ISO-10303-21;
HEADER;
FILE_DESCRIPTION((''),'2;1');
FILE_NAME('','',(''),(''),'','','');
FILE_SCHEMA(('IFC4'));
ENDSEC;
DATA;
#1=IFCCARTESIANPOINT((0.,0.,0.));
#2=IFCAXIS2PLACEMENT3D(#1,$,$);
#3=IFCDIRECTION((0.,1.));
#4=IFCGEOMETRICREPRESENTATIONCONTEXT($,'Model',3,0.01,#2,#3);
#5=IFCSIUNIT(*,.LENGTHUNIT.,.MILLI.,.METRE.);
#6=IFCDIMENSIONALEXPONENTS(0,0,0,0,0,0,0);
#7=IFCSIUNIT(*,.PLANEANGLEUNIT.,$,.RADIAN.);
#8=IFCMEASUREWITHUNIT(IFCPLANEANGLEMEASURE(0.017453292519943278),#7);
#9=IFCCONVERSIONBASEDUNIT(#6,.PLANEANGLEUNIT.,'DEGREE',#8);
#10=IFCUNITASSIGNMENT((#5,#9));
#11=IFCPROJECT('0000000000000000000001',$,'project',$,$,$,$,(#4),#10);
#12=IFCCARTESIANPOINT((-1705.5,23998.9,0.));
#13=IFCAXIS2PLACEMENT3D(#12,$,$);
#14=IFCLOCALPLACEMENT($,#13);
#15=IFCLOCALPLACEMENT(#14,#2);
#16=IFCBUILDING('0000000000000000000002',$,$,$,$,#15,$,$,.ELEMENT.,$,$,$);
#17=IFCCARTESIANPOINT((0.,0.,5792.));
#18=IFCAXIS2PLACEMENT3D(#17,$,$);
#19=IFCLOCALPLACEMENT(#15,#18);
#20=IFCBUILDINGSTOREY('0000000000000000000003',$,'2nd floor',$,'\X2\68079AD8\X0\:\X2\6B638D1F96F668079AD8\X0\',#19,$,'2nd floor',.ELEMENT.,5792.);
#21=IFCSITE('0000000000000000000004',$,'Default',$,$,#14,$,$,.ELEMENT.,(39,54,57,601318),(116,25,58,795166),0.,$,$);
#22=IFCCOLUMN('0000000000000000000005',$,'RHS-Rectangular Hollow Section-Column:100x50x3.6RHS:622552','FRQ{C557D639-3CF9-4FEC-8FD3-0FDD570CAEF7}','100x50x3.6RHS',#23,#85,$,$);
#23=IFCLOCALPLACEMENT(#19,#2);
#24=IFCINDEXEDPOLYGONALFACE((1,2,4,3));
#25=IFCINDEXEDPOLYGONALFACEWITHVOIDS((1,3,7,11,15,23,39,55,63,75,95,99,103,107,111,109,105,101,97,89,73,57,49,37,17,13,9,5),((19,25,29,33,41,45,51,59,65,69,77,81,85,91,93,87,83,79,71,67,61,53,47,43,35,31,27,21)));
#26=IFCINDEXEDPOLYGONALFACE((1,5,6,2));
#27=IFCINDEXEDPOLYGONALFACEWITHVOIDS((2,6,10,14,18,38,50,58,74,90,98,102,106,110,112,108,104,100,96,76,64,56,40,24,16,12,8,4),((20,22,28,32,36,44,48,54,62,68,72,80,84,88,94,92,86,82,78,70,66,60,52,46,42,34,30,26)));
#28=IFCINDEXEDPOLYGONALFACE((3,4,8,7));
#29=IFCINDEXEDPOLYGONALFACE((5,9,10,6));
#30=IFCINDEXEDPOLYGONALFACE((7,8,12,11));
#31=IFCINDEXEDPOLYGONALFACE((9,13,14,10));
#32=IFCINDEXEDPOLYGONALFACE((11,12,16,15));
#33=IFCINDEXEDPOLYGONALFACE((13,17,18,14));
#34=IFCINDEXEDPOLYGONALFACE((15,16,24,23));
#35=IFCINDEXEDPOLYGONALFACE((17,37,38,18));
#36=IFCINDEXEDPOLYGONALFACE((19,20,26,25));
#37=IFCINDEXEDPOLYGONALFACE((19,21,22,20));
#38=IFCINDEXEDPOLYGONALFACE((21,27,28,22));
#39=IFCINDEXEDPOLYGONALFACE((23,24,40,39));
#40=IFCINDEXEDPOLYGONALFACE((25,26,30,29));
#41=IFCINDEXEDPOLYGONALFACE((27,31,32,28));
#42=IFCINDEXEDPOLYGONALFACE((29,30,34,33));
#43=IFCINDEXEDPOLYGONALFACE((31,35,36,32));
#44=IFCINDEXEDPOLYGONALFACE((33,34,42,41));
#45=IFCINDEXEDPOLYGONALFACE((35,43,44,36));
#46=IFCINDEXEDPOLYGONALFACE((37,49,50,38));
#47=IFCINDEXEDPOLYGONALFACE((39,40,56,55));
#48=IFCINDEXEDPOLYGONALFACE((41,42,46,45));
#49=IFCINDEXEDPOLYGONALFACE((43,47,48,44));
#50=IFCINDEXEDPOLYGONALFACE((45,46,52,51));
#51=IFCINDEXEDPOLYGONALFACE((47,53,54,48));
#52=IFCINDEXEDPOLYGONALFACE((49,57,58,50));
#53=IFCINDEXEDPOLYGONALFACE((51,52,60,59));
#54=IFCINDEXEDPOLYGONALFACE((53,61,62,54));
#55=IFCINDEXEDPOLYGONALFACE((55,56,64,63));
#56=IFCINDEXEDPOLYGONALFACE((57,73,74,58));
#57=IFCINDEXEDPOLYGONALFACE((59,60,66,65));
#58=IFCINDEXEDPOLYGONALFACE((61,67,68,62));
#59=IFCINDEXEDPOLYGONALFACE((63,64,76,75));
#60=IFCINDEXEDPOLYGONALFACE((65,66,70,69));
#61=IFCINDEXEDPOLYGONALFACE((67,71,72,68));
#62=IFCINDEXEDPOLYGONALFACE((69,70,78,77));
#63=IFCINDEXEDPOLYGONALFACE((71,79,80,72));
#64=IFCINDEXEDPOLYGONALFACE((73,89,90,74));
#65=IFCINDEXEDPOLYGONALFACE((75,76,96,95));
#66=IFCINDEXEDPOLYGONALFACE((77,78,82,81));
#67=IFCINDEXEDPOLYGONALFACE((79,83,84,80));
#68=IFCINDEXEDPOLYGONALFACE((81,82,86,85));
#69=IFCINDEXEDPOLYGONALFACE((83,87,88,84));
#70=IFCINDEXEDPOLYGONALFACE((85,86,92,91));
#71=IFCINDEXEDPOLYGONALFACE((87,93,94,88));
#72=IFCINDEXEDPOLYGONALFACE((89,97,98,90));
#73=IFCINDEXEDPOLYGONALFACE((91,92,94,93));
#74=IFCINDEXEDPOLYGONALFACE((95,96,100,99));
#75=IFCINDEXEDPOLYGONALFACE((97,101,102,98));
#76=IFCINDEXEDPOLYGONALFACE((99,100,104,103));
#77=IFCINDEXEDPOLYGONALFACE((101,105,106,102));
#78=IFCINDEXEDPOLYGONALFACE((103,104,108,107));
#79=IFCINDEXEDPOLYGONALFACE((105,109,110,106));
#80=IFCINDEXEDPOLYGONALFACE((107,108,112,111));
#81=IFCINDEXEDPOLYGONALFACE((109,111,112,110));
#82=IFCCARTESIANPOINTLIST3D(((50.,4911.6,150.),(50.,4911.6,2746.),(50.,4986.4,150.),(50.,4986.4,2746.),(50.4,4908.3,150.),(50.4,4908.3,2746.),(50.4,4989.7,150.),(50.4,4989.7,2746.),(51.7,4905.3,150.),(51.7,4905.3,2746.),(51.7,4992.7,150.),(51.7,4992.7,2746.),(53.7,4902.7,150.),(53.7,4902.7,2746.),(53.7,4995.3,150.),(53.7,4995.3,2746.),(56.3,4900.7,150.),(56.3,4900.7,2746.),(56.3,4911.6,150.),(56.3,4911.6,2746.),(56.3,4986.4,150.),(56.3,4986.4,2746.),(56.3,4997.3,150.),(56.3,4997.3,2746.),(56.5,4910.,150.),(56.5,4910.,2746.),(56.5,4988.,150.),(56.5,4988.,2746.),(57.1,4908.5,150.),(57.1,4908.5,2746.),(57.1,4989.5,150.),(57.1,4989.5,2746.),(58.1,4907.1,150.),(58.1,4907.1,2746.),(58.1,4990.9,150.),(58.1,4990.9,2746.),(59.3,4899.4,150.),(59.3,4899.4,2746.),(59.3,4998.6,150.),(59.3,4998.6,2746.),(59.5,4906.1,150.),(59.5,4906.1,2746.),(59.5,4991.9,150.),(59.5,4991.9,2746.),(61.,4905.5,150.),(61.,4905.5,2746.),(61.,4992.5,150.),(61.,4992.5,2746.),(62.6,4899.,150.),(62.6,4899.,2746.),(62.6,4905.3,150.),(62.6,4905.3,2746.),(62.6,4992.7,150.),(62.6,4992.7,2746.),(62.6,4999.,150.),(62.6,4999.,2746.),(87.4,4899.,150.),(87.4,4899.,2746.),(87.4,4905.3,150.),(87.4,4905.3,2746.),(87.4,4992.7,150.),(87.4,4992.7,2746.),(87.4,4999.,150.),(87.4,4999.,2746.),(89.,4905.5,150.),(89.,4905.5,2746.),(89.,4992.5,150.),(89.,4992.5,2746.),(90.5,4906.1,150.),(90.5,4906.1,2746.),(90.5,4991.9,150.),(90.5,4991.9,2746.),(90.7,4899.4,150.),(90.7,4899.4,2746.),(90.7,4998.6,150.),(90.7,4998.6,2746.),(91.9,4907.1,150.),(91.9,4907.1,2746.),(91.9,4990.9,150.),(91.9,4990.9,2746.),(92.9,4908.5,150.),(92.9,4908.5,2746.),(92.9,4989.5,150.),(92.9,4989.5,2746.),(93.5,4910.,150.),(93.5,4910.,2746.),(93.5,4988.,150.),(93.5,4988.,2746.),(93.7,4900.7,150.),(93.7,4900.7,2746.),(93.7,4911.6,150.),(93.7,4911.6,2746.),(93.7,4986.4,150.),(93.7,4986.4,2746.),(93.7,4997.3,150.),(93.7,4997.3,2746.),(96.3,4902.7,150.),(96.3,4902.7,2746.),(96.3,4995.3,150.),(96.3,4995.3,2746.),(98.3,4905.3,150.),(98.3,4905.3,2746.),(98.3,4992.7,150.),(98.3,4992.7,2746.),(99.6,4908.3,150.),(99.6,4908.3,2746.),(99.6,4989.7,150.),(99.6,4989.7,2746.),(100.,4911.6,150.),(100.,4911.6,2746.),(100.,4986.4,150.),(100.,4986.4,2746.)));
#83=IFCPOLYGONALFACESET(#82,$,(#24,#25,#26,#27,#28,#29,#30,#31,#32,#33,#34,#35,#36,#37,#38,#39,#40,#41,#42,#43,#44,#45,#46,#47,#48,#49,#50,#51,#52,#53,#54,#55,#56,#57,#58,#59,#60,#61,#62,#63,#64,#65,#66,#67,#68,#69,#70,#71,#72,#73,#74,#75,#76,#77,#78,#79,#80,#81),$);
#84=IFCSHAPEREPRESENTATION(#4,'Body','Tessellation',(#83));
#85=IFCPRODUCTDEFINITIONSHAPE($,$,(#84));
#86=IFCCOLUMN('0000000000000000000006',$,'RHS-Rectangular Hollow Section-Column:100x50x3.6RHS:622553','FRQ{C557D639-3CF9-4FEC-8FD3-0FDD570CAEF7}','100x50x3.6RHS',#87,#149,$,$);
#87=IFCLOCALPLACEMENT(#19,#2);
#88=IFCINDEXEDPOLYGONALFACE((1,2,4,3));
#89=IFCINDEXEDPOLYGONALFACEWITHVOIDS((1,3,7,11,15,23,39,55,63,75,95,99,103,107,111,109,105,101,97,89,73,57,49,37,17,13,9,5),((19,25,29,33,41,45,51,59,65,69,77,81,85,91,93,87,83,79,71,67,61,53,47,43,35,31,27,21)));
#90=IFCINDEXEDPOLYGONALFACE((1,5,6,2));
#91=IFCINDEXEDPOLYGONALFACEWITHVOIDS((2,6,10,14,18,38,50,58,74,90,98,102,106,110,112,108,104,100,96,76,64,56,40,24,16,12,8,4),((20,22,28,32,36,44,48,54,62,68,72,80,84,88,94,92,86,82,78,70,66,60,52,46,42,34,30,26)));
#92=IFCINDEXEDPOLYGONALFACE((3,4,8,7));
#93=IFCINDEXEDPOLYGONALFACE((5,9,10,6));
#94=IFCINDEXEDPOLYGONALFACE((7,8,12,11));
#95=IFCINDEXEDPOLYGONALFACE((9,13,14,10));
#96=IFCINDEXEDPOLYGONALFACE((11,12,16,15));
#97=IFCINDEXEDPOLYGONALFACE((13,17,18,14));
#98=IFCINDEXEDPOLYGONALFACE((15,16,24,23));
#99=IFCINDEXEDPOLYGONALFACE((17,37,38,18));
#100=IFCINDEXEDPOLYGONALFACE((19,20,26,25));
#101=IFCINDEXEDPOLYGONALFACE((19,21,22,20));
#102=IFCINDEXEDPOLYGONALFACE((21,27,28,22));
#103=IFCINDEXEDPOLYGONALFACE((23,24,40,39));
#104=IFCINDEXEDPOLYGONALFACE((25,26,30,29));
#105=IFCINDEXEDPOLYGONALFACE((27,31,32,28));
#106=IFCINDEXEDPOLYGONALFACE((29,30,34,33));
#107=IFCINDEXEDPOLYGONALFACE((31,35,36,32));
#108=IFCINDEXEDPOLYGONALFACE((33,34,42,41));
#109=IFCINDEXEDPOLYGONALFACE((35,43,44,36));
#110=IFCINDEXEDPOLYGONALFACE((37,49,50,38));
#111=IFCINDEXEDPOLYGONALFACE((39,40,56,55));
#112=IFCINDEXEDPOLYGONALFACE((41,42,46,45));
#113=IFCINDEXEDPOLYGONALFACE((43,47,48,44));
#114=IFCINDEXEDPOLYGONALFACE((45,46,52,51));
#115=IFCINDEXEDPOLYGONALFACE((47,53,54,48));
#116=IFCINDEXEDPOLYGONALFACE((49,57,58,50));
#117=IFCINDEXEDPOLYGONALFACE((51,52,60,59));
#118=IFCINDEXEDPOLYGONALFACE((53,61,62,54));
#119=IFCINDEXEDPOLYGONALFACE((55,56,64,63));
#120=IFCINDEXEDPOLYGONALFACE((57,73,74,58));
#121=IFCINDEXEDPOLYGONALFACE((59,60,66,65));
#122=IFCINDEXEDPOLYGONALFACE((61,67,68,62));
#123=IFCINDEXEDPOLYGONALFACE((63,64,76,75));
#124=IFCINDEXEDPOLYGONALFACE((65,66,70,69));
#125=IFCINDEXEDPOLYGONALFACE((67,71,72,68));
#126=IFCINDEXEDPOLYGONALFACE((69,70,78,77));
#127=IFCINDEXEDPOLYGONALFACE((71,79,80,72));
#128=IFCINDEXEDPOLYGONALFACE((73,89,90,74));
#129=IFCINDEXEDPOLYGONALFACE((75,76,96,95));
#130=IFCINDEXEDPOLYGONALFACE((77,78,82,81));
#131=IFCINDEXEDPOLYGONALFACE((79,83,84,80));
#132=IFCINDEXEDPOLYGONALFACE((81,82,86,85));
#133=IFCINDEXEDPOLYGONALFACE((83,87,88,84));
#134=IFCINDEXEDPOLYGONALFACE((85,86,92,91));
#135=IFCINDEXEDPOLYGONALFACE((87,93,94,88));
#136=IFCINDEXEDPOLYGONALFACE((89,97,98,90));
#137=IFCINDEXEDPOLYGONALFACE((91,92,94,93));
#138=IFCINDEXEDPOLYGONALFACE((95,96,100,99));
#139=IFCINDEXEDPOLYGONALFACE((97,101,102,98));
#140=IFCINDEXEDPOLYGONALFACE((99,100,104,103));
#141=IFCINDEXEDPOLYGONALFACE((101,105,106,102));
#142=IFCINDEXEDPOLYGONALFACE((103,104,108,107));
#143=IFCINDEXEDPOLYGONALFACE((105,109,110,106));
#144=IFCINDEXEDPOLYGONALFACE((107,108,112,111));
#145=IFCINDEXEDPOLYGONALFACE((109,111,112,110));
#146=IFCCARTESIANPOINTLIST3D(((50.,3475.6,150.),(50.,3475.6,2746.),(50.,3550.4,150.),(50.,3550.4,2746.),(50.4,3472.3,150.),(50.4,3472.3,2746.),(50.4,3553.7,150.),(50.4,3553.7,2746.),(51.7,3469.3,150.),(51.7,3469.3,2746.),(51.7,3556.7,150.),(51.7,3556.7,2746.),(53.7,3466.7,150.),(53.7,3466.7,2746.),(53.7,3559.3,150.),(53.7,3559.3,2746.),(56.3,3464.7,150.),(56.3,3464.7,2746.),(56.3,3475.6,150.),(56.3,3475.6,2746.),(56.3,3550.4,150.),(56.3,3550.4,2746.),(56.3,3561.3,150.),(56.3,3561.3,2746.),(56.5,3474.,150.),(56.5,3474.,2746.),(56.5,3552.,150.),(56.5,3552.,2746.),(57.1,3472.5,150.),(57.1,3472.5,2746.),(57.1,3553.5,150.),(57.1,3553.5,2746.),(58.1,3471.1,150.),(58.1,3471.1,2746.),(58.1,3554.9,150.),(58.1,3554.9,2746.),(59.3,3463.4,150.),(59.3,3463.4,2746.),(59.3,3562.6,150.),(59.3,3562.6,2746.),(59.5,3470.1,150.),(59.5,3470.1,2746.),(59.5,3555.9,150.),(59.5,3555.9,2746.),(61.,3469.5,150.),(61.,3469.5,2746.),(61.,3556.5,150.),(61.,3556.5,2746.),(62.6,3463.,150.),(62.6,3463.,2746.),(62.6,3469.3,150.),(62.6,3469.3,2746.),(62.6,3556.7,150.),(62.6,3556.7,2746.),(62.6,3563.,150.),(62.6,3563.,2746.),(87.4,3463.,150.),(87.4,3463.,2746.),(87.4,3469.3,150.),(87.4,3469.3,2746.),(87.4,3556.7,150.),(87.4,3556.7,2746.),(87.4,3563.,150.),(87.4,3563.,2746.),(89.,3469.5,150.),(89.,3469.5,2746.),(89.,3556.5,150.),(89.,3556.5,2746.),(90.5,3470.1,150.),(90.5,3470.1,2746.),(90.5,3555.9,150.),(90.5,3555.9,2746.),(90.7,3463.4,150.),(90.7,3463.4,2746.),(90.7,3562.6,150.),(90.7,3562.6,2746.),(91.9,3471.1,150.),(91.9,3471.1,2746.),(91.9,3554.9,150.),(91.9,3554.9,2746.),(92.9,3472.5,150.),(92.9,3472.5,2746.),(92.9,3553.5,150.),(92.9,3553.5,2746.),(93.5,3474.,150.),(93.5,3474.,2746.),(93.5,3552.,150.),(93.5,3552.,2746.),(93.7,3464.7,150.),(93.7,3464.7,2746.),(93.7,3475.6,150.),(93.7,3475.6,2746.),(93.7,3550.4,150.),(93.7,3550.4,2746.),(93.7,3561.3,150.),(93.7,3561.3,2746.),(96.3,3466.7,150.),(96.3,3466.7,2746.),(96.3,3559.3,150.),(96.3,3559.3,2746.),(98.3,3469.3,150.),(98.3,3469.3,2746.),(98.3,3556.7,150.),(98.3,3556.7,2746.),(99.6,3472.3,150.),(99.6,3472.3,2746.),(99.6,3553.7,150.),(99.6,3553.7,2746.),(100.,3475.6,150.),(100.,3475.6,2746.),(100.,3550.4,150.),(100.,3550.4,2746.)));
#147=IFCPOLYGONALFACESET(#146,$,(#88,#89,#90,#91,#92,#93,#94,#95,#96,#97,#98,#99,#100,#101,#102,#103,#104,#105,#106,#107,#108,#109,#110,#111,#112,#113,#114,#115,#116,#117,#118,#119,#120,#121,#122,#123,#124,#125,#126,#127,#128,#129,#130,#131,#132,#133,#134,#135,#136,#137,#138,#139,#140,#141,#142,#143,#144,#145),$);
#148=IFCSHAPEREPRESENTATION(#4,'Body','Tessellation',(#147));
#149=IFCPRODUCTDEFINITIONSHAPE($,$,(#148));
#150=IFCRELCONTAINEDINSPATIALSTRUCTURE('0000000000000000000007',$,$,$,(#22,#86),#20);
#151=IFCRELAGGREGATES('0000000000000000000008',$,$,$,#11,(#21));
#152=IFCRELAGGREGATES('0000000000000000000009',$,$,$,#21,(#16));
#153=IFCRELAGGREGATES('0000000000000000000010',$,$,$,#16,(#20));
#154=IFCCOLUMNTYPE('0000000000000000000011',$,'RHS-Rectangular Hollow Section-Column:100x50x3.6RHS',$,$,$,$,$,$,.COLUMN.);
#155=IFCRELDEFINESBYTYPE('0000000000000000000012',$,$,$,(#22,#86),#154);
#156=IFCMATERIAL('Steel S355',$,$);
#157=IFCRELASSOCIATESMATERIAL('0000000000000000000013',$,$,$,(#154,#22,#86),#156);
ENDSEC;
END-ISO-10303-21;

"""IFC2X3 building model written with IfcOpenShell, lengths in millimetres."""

from ifc_helpers import new_model, entity, si_unit, converted_unit, direction, frame, origin, origin_2d, place, context, project, spatial, hollow_rectangle, extrude, clip, halfspace, material, type_object, element, save


model = new_model("IFC2X3")

# Units and contexts
model_context = context("Model", 3, precision=0.01, world=origin(), true_north=direction((0.0, 1.0)))
ifc_project = project(units=[si_unit("LENGTHUNIT", "METRE", prefix="MILLI"), converted_unit("PLANEANGLEUNIT", "DEGREE", entity("IfcPlaneAngleMeasure", 0.017453292519943278), si_unit("PLANEANGLEUNIT", "RADIAN"), dimensions=[0, 0, 0, 0, 0, 0, 0])], contexts=[model_context])

# Site, building, storey
site_placement = place(None, frame((-1705.5, 23998.9, 0.0)))
site = spatial("IfcSite", under=ifc_project, at=site_placement, Name="Default", CompositionType="ELEMENT", RefLatitude=(39, 54, 57, 601318), RefLongitude=(116, 25, 58, 795166), RefElevation=0.0)
building_placement = place(site_placement, origin())
building = spatial("IfcBuilding", under=site, at=building_placement, CompositionType="ELEMENT")
storey_placement = place(building_placement, frame((0.0, 0.0, 5792.0)))
storey = spatial("IfcBuildingStorey", under=building, at=storey_placement, Name="2nd floor", ObjectType="标高:正负零标高", LongName="2nd floor", CompositionType="ELEMENT", Elevation=5792.0)

# Columns
ifc_material_1 = material(Name="Steel S355")
column_type_1 = type_object("IfcColumnType", Name="RHS-Rectangular Hollow Section-Column:100x50x3.6RHS", PredefinedType="COLUMN", material=ifc_material_1)
column_1_placement = place(storey_placement, frame((75.0, 4949.0, 2746.0), z_axis=(0.0, 0.0, 1.0), x_axis=(-1.0, 0.0, 0.0)))
element("IfcColumn", 1, at=column_1_placement, inside=storey, type_object=column_type_1, material=ifc_material_1, Name="RHS-Rectangular Hollow Section-Column:100x50x3.6RHS:622552", Description="FRQ{C557D639-3CF9-4FEC-8FD3-0FDD570CAEF7}", ObjectType="100x50x3.6RHS", context=model_context, shape_type="Clipping", body=[
    clip(extrude(hollow_rectangle(XDim=50.0, YDim=100.0, WallThickness=6.3, InnerFilletRadius=6.3, OuterFilletRadius=12.6, at=origin_2d()), origin(), (0.0, 0.0, -1.0), 2651.9), halfspace(frame((75.0, 4949.0, -2596.0), z_axis=(0.0, 0.0, 1.0), x_axis=(-1.0, 0.0, 0.0)), True)),
])
column_2_placement = place(storey_placement, frame((75.0, 3513.0, 2746.0), z_axis=(0.0, 0.0, 1.0), x_axis=(-1.0, 0.0, 0.0)))
element("IfcColumn", 2, at=column_2_placement, inside=storey, type_object=column_type_1, material=ifc_material_1, Name="RHS-Rectangular Hollow Section-Column:100x50x3.6RHS:622553", Description="FRQ{C557D639-3CF9-4FEC-8FD3-0FDD570CAEF7}", ObjectType="100x50x3.6RHS", context=model_context, shape_type="Clipping", body=[
    clip(extrude(hollow_rectangle(XDim=50.0, YDim=100.0, WallThickness=6.3, InnerFilletRadius=6.3, OuterFilletRadius=12.6, at=origin_2d()), origin(), (0.0, 0.0, -1.0), 2651.9), halfspace(frame((75.0, 3513.0, -2596.0), z_axis=(0.0, 0.0, 1.0), x_axis=(-1.0, 0.0, 0.0)), True)),
])

save(model, "model.ifc")
